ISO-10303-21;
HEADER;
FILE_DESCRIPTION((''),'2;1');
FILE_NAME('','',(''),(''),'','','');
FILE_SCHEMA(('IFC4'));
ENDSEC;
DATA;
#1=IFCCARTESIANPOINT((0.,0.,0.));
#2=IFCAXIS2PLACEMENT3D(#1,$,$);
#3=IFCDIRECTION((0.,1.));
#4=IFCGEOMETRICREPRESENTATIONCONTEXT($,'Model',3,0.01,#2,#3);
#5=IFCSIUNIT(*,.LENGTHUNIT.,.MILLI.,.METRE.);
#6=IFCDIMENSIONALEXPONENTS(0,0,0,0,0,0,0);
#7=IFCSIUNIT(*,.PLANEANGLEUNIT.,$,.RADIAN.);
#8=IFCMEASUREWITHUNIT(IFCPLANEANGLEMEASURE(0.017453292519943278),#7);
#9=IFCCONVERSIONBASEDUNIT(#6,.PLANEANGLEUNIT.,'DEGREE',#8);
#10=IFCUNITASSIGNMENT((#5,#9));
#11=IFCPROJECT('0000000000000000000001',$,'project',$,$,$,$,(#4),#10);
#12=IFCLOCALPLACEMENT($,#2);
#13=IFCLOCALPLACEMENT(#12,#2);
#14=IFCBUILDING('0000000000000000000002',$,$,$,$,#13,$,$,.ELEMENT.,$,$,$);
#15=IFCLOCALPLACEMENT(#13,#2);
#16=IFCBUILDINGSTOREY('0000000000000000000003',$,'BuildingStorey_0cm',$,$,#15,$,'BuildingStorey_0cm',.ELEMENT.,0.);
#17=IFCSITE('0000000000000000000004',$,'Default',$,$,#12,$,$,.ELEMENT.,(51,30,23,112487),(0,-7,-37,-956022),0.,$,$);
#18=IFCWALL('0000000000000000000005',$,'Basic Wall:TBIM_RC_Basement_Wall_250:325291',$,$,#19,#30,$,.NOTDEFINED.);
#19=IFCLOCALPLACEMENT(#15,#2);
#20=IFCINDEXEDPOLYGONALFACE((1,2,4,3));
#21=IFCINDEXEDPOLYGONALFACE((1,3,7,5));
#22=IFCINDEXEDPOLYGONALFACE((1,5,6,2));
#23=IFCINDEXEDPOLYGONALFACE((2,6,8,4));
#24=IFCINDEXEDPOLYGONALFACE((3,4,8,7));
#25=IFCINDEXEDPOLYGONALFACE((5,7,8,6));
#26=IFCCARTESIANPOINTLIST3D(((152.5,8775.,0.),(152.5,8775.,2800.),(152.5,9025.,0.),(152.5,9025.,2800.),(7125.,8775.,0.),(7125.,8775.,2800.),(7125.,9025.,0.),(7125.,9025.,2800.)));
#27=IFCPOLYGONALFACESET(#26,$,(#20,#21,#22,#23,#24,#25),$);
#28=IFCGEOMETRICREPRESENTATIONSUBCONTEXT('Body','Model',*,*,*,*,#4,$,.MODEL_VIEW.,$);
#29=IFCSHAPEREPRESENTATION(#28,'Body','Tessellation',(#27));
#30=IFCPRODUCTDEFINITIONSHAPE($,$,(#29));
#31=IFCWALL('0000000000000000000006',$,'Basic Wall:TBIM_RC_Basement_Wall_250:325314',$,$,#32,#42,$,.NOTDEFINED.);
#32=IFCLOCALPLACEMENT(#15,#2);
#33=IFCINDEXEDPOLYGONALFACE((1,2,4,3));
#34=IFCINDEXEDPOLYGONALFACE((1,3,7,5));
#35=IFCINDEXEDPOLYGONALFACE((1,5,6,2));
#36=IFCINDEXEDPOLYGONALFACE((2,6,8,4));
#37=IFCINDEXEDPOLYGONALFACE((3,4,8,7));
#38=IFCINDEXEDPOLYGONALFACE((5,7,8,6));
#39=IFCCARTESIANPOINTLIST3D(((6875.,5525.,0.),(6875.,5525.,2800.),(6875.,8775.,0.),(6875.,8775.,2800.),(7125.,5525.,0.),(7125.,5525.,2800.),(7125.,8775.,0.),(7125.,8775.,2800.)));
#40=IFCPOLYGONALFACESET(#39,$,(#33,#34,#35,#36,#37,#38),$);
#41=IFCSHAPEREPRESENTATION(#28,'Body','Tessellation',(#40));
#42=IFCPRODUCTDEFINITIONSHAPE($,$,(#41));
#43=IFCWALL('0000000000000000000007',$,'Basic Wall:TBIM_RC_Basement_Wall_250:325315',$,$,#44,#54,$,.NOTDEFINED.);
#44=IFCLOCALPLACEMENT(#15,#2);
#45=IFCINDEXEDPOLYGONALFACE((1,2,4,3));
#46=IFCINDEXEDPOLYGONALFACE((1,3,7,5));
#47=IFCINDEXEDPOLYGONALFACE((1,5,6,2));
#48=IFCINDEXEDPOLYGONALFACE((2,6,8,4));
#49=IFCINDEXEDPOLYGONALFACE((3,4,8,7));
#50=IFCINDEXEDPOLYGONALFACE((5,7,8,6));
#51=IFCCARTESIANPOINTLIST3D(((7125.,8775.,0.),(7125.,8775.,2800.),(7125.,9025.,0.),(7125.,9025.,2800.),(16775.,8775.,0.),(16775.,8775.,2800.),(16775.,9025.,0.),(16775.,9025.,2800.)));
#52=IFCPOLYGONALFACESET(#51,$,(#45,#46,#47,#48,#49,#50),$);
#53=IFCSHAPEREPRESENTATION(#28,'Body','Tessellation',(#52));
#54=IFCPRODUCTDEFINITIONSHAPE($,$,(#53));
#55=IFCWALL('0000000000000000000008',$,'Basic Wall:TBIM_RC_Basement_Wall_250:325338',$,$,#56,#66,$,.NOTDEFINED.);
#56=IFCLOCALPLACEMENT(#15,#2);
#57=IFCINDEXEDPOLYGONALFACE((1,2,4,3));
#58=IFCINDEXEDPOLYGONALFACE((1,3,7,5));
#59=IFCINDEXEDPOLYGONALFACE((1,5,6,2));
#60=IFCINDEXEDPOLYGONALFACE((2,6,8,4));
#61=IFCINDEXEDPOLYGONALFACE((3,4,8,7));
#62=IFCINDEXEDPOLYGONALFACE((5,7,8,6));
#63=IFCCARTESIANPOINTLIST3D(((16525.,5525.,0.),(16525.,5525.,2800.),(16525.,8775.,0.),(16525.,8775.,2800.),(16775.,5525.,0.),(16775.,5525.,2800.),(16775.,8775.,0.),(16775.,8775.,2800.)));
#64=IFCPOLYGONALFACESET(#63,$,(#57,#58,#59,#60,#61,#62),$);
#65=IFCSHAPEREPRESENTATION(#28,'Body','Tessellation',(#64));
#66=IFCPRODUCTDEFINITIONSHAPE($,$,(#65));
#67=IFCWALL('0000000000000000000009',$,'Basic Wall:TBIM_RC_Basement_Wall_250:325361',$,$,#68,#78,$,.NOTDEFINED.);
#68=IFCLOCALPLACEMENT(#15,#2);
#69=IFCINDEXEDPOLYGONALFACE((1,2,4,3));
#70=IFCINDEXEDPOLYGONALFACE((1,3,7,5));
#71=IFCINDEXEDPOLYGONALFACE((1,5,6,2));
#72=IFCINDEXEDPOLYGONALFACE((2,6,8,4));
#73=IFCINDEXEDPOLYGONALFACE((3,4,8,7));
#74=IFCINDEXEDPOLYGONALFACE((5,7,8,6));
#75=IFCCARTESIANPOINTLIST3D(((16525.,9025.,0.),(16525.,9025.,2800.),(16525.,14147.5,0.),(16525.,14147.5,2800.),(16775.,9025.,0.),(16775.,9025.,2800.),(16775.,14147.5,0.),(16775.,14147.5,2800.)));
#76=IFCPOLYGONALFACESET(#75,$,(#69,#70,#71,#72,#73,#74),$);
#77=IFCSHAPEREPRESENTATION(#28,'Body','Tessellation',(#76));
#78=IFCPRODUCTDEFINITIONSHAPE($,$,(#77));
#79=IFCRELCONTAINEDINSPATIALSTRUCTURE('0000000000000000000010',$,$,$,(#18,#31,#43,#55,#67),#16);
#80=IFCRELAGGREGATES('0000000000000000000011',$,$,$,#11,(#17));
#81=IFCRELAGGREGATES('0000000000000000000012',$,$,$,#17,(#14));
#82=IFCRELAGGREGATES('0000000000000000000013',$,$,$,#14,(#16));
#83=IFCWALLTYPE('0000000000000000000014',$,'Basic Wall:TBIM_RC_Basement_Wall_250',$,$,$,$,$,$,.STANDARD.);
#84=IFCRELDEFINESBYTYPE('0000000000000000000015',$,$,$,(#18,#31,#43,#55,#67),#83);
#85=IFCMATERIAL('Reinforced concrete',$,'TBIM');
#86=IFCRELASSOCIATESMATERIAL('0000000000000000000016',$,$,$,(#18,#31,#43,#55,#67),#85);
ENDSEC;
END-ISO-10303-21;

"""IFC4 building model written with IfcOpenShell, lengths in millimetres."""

from ifc_helpers import new_model, entity, si_unit, converted_unit, direction, frame, origin, place, context, subcontext, project, spatial, indexed_curve, outline, extrude, material, type_object, element, save


model = new_model("IFC4")

# Units and contexts
model_context = context("Model", 3, precision=0.01, world=origin(), true_north=direction((0.0, 1.0)))
body_context = subcontext(model_context, "Body", "Model", "MODEL_VIEW")
ifc_project = project(units=[si_unit("LENGTHUNIT", "METRE", prefix="MILLI"), converted_unit("PLANEANGLEUNIT", "DEGREE", entity("IfcPlaneAngleMeasure", 0.017453292519943278), si_unit("PLANEANGLEUNIT", "RADIAN"), dimensions=[0, 0, 0, 0, 0, 0, 0])], contexts=[model_context])

# Site, building, storey
site_placement = place(None, origin())
site = spatial("IfcSite", under=ifc_project, at=site_placement, Name="Default", CompositionType="ELEMENT", RefLatitude=(51, 30, 23, 112487), RefLongitude=(0, -7, -37, -956022), RefElevation=0.0)
building_placement = place(site_placement, origin())
building = spatial("IfcBuilding", under=site, at=building_placement, CompositionType="ELEMENT")
storey_placement = place(building_placement, origin())
storey = spatial("IfcBuildingStorey", under=building, at=storey_placement, Name="BuildingStorey_0cm", LongName="BuildingStorey_0cm", CompositionType="ELEMENT", Elevation=0.0)

# Shared definitions
ifc_material_1 = material(Name="Reinforced concrete", Category="TBIM")

# Walls
wall_type_1 = type_object("IfcWallType", Name="Basic Wall:TBIM_RC_Basement_Wall_250", PredefinedType="STANDARD")
wall_1_placement = place(storey_placement, frame((152.5, 8900.0, 0.0)))
element("IfcWall", 1, at=wall_1_placement, inside=storey, type_object=wall_type_1, material=ifc_material_1, Name="Basic Wall:TBIM_RC_Basement_Wall_250:325291", PredefinedType="NOTDEFINED", context=body_context, shape_type="SweptSolid", body=[
    extrude(outline(indexed_curve([(6972.5, 125.0), (0.0, 125.0), (0.0, -125.0), (6972.5, -125.0), (6972.5, 125.0)], self_intersect=False)), origin(), (0.0, 0.0, 1.0), 2800.0),
])
wall_2_placement = place(storey_placement, frame((7000.0, 5525.0, 0.0), z_axis=(0.0, 0.0, 1.0), x_axis=(0.0, 1.0, 0.0)))
element("IfcWall", 2, at=wall_2_placement, inside=storey, type_object=wall_type_1, material=ifc_material_1, Name="Basic Wall:TBIM_RC_Basement_Wall_250:325314", PredefinedType="NOTDEFINED", context=body_context, shape_type="SweptSolid", body=[
    extrude(outline(indexed_curve([(3250.0, 125.0), (0.0, 125.0), (0.0, -125.0), (3250.0, -125.0), (3250.0, 125.0)], self_intersect=False)), origin(), (0.0, 0.0, 1.0), 2800.0),
])
wall_3_placement = place(storey_placement, frame((7125.0, 8900.0, 0.0)))
element("IfcWall", 3, at=wall_3_placement, inside=storey, type_object=wall_type_1, material=ifc_material_1, Name="Basic Wall:TBIM_RC_Basement_Wall_250:325315", PredefinedType="NOTDEFINED", context=body_context, shape_type="SweptSolid", body=[
    extrude(outline(indexed_curve([(9650.0, 125.0), (0.0, 125.0), (0.0, -125.0), (9650.0, -125.0), (9650.0, 125.0)], self_intersect=False)), origin(), (0.0, 0.0, 1.0), 2800.0),
])
wall_4_placement = place(storey_placement, frame((16650.0, 5525.0, 0.0), z_axis=(0.0, 0.0, 1.0), x_axis=(0.0, 1.0, 0.0)))
element("IfcWall", 4, at=wall_4_placement, inside=storey, type_object=wall_type_1, material=ifc_material_1, Name="Basic Wall:TBIM_RC_Basement_Wall_250:325338", PredefinedType="NOTDEFINED", context=body_context, shape_type="SweptSolid", body=[
    extrude(outline(indexed_curve([(3250.0, 125.0), (0.0, 125.0), (0.0, -125.0), (3250.0, -125.0), (3250.0, 125.0)], self_intersect=False)), origin(), (0.0, 0.0, 1.0), 2800.0),
])
wall_5_placement = place(storey_placement, frame((16650.0, 9025.0, 0.0), z_axis=(0.0, 0.0, 1.0), x_axis=(0.0, 1.0, 0.0)))
element("IfcWall", 5, at=wall_5_placement, inside=storey, type_object=wall_type_1, material=ifc_material_1, Name="Basic Wall:TBIM_RC_Basement_Wall_250:325361", PredefinedType="NOTDEFINED", context=body_context, shape_type="SweptSolid", body=[
    extrude(outline(indexed_curve([(5122.5, 125.0), (0.0, 125.0), (0.0, -125.0), (5122.5, -125.0), (5122.5, 125.0)], self_intersect=False)), origin(), (0.0, 0.0, 1.0), 2800.0),
])

save(model, "model.ifc")
